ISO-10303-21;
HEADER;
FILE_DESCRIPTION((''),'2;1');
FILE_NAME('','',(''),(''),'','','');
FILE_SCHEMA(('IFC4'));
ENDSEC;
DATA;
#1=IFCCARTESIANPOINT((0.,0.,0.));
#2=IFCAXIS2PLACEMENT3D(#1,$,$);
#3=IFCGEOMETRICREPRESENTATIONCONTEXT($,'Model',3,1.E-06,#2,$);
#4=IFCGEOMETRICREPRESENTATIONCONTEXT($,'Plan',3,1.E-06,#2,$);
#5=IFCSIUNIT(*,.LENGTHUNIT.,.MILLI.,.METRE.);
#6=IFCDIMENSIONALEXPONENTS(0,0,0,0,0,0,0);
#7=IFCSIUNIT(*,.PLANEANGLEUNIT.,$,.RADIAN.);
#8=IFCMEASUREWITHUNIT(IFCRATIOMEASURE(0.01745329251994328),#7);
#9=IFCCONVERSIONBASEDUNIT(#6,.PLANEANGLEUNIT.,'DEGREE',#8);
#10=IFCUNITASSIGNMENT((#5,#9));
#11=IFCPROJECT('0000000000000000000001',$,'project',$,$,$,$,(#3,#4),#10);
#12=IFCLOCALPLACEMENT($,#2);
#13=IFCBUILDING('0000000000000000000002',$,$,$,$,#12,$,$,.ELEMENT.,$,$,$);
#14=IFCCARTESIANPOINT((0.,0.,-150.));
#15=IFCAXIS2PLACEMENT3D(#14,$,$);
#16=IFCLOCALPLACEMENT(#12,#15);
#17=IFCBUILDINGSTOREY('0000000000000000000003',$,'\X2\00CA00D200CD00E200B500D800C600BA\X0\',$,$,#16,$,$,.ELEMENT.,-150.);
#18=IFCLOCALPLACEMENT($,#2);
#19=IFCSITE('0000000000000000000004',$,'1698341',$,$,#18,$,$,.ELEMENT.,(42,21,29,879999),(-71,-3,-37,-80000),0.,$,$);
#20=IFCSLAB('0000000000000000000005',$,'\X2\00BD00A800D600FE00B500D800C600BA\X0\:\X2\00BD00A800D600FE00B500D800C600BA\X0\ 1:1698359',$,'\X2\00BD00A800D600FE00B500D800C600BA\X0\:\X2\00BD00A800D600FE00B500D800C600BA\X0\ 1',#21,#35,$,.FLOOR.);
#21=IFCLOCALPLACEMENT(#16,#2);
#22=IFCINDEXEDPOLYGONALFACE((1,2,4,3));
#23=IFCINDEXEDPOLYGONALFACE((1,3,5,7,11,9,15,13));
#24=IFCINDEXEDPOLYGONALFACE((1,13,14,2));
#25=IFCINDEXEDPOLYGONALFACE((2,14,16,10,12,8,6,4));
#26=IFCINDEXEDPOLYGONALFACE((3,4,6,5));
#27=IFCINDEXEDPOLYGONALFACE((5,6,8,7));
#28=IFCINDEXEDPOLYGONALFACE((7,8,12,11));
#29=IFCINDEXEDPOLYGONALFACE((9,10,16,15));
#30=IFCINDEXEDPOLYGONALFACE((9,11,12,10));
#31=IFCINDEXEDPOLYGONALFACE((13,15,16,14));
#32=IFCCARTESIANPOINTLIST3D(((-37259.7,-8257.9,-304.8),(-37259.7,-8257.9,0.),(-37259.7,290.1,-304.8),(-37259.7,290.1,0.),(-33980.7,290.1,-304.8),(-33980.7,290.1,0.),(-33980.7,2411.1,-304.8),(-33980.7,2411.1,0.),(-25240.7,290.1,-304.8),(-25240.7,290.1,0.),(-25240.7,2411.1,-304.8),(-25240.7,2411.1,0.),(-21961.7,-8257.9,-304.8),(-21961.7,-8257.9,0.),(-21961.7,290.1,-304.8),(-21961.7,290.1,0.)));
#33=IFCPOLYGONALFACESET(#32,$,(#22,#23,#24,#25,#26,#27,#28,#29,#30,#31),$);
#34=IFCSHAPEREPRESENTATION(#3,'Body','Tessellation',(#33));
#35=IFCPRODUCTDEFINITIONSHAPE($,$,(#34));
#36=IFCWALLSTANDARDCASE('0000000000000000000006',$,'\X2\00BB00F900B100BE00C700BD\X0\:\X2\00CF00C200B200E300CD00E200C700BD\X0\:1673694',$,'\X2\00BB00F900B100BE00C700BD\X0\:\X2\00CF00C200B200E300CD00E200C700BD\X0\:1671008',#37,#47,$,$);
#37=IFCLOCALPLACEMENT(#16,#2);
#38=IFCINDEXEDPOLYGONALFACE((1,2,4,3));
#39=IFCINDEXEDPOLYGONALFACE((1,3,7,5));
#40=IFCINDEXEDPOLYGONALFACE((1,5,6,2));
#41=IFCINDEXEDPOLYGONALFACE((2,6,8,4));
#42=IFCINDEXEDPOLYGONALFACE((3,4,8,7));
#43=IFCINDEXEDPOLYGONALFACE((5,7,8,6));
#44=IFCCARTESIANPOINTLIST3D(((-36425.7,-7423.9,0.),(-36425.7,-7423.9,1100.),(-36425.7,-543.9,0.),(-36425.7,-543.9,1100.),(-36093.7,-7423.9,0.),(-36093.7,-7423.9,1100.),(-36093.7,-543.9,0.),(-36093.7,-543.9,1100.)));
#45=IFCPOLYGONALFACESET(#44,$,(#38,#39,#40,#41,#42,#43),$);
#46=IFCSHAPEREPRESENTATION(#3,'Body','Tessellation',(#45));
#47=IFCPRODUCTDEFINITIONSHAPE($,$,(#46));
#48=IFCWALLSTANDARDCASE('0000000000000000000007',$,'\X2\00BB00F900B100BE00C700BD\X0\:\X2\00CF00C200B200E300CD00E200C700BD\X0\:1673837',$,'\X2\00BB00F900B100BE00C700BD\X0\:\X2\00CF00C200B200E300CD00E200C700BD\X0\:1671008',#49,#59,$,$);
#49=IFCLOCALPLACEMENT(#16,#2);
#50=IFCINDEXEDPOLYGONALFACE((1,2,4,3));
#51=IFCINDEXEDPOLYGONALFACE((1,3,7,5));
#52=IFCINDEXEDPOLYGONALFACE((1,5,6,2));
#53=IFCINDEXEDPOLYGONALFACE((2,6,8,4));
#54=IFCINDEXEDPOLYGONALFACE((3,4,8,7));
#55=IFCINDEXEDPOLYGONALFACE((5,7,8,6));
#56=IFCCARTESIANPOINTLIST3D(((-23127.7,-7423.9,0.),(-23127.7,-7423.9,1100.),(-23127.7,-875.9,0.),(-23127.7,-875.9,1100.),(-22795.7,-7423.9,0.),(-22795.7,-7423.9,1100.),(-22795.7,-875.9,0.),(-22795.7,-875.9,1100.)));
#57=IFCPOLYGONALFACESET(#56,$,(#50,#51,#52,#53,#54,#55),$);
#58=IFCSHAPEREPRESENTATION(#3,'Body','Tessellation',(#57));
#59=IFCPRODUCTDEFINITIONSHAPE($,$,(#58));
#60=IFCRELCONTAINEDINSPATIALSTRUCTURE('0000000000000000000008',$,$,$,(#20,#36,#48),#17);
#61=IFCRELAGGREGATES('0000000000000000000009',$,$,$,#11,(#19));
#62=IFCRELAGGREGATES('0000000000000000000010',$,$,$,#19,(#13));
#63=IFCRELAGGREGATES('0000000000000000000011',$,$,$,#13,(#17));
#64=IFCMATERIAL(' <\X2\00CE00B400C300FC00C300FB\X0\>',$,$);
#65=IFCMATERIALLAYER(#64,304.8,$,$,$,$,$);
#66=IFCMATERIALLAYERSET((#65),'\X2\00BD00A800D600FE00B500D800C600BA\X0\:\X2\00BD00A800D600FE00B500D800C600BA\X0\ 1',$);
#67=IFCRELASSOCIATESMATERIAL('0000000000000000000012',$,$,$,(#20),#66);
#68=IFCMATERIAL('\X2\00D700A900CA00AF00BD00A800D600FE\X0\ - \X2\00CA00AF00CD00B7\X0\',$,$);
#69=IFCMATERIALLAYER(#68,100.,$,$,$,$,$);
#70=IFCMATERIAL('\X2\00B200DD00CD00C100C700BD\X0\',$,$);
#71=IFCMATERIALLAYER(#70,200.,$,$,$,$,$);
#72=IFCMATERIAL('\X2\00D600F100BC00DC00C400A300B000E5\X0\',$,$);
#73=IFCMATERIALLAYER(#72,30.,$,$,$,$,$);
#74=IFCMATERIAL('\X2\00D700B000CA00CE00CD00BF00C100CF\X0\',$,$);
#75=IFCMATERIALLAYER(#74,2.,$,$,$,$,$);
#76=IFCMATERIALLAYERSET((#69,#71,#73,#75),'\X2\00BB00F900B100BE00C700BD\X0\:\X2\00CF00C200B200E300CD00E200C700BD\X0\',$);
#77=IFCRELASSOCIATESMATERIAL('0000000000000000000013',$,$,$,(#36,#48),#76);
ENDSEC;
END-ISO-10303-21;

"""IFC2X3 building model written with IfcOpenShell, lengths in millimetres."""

from ifc_helpers import new_model, entity, si_unit, converted_unit, frame, frame_2d, origin, place, context, project, spatial, polyline, rectangle, outline, extrude, material, layer, layer_set, layer_usage, element, save


model = new_model("IFC2X3")

# Units and contexts
model_context = context("Model", 3, precision=1e-06, world=origin())
plan_context = context("Plan", 3, precision=1e-06, world=origin())
ifc_project = project(units=[si_unit("LENGTHUNIT", "METRE", prefix="MILLI"), converted_unit("PLANEANGLEUNIT", "DEGREE", entity("IfcRatioMeasure", 0.01745329251994328), si_unit("PLANEANGLEUNIT", "RADIAN"), dimensions=[0, 0, 0, 0, 0, 0, 0])], contexts=[model_context, plan_context])

# Site, building, storey
site_placement = place(None, origin())
site = spatial("IfcSite", under=ifc_project, at=site_placement, Name="1698341", CompositionType="ELEMENT", RefLatitude=(42, 21, 29, 879999), RefLongitude=(-71, -3, -37, -80000), RefElevation=0.0)
building_placement = place(None, origin())
building = spatial("IfcBuilding", under=site, at=building_placement, CompositionType="ELEMENT")
storey_placement = place(building_placement, frame((0.0, 0.0, -150.0)))
storey = spatial("IfcBuildingStorey", under=building, at=storey_placement, Name="ÊÒÍâµØÆº", CompositionType="ELEMENT", Elevation=-150.0)

# Slab
ifc_material_1 = material(Name=" <Î´ÃüÃû>")
ifc_layer_1 = layer(ifc_material_1, 304.8)
ifc_layer_set_1 = layer_set([ifc_layer_1], Name="½¨ÖþµØÆº:½¨ÖþµØÆº 1")
ifc_layer_usage_1 = layer_usage(ifc_layer_set_1, "AXIS3", "NEGATIVE", 0.0)
slab_placement = place(storey_placement, frame((-37259.7, -8257.9, -304.8)))
element("IfcSlab", 1, at=slab_placement, inside=storey, material=ifc_layer_usage_1, Name="½¨ÖþµØÆº:½¨ÖþµØÆº 1:1698359", ObjectType="½¨ÖþµØÆº:½¨ÖþµØÆº 1", PredefinedType="FLOOR", context=model_context, shape_type="SweptSolid", body=[
    extrude(outline(polyline([(7649.0, 3213.5), (4370.0, 3213.5), (4370.0, 5334.5), (-4370.0, 5334.5), (-4370.0, 3213.5), (-7649.0, 3213.5), (-7649.0, -5334.5), (7649.0, -5334.5), (7649.0, 3213.5)])), frame((7649.0, 5334.5, 304.8), z_axis=(0.0, 0.0, -1.0), x_axis=(-1.0, 0.0, 0.0)), (0.0, 0.0, 1.0), 304.8),
])

# Wall
ifc_material_2 = material(Name="×©Ê¯½¨Öþ - Ê¯Í·")
ifc_layer_2 = layer(ifc_material_2, 100.0)
ifc_material_3 = material(Name="²ÝÍÁÇ½")
ifc_layer_3 = layer(ifc_material_3, 200.0)
ifc_material_4 = material(Name="Öñ¼ÜÄ£°å")
ifc_layer_4 = layer(ifc_material_4, 30.0)
ifc_material_5 = material(Name="×°ÊÎÍ¿ÁÏ")
ifc_layer_5 = layer(ifc_material_5, 2.0)
ifc_layer_set_2 = layer_set([ifc_layer_2, ifc_layer_3, ifc_layer_4, ifc_layer_5], Name="»ù±¾Ç½:ÏÂ²ãÍâÇ½")
ifc_layer_usage_2 = layer_usage(ifc_layer_set_2, "AXIS2", "NEGATIVE", 166.0)
wall_1_placement = place(storey_placement, frame((-36259.7, -7423.9, 0.0), z_axis=(0.0, 0.0, 1.0), x_axis=(0.0, 1.0, 0.0)))
element("IfcWallStandardCase", 2, at=wall_1_placement, inside=storey, material=ifc_layer_usage_2, Name="»ù±¾Ç½:ÏÂ²ãÍâÇ½:1673694", ObjectType="»ù±¾Ç½:ÏÂ²ãÍâÇ½:1671008", context=model_context, shape_type="SweptSolid", body=[
    extrude(rectangle(XDim=6880.0, YDim=332.0, at=frame_2d((3440.0, 0.0), x_axis=(-1.0, 0.0))), origin(), (0.0, 0.0, 1.0), 1100.0),
])

# Wall
ifc_layer_usage_3 = layer_usage(ifc_layer_set_2, "AXIS2", "NEGATIVE", 166.0)
wall_2_placement = place(storey_placement, frame((-22961.7, -875.9, 0.0), z_axis=(0.0, 0.0, 1.0), x_axis=(0.0, -1.0, 0.0)))
element("IfcWallStandardCase", 3, at=wall_2_placement, inside=storey, material=ifc_layer_usage_3, Name="»ù±¾Ç½:ÏÂ²ãÍâÇ½:1673837", ObjectType="»ù±¾Ç½:ÏÂ²ãÍâÇ½:1671008", context=model_context, shape_type="SweptSolid", body=[
    extrude(rectangle(XDim=6548.0, YDim=332.0, at=frame_2d((3274.0, 0.0), x_axis=(-1.0, 0.0))), origin(), (0.0, 0.0, 1.0), 1100.0),
])

save(model, "model.ifc")
